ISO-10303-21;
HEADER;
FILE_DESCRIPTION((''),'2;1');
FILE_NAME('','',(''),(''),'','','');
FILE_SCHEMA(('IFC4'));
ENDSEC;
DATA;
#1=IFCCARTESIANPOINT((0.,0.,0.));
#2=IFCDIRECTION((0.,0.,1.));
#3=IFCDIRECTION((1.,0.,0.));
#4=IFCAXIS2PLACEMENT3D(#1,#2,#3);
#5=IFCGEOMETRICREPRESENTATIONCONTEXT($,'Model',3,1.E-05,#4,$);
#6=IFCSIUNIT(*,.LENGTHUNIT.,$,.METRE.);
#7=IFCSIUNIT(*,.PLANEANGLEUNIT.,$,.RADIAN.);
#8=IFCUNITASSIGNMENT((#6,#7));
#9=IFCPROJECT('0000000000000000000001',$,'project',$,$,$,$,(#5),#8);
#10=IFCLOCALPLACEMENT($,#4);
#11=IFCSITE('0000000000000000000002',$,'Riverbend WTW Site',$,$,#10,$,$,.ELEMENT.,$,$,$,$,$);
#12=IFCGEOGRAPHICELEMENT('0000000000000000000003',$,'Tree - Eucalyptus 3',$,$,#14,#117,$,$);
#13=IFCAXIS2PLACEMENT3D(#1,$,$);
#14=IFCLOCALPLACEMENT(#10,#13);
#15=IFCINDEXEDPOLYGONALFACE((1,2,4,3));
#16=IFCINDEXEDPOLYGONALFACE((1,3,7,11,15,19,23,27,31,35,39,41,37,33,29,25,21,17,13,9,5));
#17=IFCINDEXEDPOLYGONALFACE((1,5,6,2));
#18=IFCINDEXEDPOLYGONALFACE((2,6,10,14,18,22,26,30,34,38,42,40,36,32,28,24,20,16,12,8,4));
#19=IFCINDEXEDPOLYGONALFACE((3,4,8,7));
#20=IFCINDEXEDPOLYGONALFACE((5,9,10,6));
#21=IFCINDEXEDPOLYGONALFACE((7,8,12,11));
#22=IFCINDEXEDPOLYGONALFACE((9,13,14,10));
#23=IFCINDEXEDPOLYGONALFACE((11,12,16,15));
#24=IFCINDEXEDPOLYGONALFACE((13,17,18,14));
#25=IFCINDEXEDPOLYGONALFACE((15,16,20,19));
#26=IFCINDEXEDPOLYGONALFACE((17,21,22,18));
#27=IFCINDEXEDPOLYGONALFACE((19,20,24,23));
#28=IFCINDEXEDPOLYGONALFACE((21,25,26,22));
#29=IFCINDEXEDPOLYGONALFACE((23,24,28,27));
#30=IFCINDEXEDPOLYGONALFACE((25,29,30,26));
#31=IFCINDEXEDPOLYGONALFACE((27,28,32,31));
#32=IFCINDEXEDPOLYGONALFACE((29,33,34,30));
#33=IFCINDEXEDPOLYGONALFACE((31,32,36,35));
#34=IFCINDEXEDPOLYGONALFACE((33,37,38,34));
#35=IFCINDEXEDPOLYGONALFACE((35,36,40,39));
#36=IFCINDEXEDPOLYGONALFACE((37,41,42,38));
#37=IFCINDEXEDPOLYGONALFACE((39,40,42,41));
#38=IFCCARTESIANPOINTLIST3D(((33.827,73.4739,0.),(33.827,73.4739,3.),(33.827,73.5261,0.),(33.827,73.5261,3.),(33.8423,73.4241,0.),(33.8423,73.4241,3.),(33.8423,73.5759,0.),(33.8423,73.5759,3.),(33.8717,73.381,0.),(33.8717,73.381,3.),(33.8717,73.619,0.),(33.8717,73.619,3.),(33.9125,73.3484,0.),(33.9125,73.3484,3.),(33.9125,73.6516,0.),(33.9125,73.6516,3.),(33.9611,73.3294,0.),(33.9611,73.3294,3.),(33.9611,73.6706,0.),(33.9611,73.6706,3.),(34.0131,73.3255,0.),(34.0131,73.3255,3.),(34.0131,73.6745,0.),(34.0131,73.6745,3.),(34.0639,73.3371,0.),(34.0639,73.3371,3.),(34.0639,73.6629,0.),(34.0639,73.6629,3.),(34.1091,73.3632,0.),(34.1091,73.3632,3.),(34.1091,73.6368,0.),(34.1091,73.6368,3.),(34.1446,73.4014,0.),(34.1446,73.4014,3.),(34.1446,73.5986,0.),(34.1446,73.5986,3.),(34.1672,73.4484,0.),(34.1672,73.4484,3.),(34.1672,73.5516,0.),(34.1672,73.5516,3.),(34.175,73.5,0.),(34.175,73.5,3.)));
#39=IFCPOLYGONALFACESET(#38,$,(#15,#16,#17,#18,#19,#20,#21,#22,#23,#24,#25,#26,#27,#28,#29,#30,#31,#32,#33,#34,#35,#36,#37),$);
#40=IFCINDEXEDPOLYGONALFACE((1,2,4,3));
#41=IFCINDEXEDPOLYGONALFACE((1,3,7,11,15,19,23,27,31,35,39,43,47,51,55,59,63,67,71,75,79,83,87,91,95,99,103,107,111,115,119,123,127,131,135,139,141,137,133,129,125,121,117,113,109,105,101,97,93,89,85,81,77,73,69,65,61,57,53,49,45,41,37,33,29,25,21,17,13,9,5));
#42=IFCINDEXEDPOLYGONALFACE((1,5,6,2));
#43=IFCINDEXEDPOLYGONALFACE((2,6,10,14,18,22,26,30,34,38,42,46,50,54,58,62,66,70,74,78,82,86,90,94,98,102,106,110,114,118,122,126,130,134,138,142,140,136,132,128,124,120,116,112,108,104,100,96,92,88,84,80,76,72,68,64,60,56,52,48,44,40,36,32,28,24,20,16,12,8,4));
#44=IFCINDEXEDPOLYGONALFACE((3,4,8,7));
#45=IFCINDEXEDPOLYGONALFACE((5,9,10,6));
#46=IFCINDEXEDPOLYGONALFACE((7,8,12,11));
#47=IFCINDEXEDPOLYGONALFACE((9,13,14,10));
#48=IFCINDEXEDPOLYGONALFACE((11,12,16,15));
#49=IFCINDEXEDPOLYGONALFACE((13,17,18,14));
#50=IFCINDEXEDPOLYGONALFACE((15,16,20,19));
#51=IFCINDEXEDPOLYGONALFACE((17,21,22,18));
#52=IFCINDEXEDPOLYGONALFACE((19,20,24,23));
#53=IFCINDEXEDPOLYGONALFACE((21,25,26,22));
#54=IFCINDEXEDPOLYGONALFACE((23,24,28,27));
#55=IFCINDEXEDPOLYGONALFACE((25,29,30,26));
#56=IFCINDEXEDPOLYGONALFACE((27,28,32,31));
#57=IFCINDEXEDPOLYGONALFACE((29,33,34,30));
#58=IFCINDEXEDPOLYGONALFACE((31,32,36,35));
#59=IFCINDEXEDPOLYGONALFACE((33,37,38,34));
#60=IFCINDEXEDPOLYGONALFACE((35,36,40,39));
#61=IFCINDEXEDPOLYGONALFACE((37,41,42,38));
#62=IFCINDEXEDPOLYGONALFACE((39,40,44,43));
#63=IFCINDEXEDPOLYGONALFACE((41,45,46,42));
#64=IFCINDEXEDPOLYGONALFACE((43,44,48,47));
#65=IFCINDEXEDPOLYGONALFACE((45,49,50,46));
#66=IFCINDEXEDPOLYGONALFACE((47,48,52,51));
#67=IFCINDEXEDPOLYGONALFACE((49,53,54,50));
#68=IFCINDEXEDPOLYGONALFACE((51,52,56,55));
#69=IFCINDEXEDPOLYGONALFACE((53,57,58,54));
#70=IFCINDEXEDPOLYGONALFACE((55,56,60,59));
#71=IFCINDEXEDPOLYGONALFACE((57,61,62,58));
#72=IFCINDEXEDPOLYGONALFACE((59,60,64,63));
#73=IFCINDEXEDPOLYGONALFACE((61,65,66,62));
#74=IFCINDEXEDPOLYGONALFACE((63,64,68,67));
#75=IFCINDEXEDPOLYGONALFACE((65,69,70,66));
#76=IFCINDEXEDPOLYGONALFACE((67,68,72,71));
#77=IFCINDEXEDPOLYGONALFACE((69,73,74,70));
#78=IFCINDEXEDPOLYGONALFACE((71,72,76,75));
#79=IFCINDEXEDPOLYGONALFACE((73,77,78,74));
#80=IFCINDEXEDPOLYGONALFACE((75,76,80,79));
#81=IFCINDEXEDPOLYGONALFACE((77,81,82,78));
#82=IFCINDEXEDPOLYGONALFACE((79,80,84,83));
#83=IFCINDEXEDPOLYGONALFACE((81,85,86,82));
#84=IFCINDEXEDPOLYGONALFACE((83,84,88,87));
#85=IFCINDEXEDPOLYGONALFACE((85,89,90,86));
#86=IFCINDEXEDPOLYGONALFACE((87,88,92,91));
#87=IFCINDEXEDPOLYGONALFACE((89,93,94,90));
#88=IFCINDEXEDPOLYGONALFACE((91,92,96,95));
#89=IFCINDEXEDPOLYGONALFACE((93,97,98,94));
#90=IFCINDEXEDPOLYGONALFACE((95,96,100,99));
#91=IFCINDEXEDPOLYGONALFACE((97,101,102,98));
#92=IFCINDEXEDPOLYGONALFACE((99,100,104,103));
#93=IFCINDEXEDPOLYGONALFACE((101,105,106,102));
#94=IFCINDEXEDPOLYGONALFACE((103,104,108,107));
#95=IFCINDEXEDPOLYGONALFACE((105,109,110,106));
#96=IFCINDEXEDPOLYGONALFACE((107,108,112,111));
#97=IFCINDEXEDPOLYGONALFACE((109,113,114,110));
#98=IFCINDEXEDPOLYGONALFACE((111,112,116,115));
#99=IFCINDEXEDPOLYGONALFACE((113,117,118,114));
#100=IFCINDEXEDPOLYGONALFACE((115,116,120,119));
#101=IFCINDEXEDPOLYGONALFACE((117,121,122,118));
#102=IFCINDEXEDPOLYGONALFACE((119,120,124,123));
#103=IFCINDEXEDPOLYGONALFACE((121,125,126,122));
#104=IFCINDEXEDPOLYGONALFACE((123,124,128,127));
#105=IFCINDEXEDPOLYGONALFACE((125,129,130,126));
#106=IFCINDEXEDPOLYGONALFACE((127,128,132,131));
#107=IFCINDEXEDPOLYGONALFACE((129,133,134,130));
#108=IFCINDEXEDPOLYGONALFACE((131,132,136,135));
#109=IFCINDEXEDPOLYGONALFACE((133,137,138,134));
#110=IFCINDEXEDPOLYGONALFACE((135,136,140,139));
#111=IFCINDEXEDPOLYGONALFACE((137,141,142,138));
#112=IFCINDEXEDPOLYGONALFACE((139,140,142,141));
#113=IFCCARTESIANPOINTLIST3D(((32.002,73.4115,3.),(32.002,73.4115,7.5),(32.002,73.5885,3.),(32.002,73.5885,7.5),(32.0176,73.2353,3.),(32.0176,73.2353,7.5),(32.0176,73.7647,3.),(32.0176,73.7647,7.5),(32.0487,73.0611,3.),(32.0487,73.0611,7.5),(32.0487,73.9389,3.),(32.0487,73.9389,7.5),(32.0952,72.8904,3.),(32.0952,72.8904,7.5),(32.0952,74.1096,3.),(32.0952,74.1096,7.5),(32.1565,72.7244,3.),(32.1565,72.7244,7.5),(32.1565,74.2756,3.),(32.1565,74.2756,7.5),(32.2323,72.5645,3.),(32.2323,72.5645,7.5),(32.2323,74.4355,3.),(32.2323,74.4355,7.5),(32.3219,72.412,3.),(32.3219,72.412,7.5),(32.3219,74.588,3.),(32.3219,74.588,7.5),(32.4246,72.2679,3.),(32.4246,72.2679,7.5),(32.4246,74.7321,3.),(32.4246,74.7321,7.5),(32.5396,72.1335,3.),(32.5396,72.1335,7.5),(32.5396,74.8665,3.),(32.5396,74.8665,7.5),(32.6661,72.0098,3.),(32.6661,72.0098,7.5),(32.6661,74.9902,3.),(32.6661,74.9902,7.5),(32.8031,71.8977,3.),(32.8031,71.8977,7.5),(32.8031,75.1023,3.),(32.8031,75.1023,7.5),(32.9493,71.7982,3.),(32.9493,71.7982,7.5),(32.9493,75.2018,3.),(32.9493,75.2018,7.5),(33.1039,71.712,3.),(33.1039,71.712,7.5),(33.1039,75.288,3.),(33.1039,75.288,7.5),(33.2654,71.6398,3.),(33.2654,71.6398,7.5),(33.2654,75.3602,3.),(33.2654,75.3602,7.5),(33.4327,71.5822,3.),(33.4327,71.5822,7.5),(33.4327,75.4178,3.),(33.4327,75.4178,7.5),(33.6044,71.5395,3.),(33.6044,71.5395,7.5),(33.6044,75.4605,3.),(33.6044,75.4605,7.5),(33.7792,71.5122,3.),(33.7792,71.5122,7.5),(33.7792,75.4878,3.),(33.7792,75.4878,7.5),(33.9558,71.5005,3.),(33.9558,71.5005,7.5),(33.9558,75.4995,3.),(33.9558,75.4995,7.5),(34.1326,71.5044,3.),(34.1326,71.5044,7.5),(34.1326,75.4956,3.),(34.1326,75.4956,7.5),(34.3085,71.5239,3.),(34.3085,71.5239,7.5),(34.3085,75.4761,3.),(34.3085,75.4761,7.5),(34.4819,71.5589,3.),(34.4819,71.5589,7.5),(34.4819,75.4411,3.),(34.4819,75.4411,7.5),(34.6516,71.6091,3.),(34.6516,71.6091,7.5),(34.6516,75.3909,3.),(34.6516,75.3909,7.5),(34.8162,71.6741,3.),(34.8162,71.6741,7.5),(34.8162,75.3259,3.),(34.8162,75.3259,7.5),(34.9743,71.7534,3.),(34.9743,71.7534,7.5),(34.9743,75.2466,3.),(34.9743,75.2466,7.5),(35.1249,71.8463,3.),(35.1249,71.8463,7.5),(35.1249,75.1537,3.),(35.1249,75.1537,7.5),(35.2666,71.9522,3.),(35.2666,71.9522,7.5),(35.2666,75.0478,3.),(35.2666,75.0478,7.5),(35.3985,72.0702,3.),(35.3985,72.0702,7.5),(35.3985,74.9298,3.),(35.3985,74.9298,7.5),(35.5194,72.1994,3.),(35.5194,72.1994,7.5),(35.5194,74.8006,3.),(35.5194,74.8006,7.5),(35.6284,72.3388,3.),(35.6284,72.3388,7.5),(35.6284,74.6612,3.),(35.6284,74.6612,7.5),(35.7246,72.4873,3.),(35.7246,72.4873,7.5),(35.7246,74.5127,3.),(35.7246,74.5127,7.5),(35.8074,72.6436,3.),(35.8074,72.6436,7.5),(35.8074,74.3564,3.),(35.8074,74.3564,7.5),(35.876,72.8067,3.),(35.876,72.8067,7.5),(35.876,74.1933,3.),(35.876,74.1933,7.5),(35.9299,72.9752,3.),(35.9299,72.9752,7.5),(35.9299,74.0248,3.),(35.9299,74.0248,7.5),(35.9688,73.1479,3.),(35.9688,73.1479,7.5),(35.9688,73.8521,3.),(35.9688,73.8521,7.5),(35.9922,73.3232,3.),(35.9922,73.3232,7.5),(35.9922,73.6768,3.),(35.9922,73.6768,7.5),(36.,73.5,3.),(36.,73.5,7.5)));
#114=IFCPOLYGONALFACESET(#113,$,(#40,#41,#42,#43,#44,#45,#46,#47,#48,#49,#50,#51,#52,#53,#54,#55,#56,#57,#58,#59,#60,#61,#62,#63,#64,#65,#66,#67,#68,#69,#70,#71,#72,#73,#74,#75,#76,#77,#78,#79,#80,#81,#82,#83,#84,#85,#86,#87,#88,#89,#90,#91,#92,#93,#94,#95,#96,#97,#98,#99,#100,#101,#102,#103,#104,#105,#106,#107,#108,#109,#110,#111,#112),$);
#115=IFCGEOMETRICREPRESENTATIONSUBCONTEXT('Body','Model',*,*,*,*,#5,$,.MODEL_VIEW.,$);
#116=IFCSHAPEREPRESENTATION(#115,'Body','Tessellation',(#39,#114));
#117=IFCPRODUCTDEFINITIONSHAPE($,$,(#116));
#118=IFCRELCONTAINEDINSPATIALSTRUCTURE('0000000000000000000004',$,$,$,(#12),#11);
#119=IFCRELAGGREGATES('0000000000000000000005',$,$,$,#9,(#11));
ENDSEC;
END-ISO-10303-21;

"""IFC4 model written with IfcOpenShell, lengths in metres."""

from ifc_helpers import new_model, si_unit, frame, origin_with_axes, origin_2d, place, context, subcontext, project, spatial, circle, extrude, element, save


model = new_model("IFC4")

# Units and contexts
model_context = context("Model", 3, precision=1e-05, world=origin_with_axes())
body_context = subcontext(model_context, "Body", "Model", "MODEL_VIEW")
ifc_project = project(units=[si_unit("LENGTHUNIT", "METRE"), si_unit("PLANEANGLEUNIT", "RADIAN")], contexts=[model_context])

# Site
site_placement = place(None, origin_with_axes())
site = spatial("IfcSite", under=ifc_project, at=site_placement, Name="Riverbend WTW Site", CompositionType="ELEMENT")

# Geographic element
for number, where, z_axis, x_axis, name in (
    (1, (34.0, 73.5, 0.0), (0.0, 0.0, 1.0), (1.0, 0.0, 0.0), "Tree - Eucalyptus 3"),
):
    element("IfcGeographicElement", number, at=place(None, frame(where, z_axis=z_axis, x_axis=x_axis)), inside=site, Name=name, context=body_context, shape_type="SweptSolid", body=[
        extrude(circle(Radius=0.175, at=origin_2d()), origin_with_axes(), (0.0, 0.0, 1.0), 3.0),
        extrude(circle(Radius=2.0, at=origin_2d()), frame((0.0, 0.0, 3.0), z_axis=(0.0, 0.0, 1.0), x_axis=(1.0, 0.0, 0.0)), (0.0, 0.0, 1.0), 4.5),
    ])

save(model, "model.ifc")
